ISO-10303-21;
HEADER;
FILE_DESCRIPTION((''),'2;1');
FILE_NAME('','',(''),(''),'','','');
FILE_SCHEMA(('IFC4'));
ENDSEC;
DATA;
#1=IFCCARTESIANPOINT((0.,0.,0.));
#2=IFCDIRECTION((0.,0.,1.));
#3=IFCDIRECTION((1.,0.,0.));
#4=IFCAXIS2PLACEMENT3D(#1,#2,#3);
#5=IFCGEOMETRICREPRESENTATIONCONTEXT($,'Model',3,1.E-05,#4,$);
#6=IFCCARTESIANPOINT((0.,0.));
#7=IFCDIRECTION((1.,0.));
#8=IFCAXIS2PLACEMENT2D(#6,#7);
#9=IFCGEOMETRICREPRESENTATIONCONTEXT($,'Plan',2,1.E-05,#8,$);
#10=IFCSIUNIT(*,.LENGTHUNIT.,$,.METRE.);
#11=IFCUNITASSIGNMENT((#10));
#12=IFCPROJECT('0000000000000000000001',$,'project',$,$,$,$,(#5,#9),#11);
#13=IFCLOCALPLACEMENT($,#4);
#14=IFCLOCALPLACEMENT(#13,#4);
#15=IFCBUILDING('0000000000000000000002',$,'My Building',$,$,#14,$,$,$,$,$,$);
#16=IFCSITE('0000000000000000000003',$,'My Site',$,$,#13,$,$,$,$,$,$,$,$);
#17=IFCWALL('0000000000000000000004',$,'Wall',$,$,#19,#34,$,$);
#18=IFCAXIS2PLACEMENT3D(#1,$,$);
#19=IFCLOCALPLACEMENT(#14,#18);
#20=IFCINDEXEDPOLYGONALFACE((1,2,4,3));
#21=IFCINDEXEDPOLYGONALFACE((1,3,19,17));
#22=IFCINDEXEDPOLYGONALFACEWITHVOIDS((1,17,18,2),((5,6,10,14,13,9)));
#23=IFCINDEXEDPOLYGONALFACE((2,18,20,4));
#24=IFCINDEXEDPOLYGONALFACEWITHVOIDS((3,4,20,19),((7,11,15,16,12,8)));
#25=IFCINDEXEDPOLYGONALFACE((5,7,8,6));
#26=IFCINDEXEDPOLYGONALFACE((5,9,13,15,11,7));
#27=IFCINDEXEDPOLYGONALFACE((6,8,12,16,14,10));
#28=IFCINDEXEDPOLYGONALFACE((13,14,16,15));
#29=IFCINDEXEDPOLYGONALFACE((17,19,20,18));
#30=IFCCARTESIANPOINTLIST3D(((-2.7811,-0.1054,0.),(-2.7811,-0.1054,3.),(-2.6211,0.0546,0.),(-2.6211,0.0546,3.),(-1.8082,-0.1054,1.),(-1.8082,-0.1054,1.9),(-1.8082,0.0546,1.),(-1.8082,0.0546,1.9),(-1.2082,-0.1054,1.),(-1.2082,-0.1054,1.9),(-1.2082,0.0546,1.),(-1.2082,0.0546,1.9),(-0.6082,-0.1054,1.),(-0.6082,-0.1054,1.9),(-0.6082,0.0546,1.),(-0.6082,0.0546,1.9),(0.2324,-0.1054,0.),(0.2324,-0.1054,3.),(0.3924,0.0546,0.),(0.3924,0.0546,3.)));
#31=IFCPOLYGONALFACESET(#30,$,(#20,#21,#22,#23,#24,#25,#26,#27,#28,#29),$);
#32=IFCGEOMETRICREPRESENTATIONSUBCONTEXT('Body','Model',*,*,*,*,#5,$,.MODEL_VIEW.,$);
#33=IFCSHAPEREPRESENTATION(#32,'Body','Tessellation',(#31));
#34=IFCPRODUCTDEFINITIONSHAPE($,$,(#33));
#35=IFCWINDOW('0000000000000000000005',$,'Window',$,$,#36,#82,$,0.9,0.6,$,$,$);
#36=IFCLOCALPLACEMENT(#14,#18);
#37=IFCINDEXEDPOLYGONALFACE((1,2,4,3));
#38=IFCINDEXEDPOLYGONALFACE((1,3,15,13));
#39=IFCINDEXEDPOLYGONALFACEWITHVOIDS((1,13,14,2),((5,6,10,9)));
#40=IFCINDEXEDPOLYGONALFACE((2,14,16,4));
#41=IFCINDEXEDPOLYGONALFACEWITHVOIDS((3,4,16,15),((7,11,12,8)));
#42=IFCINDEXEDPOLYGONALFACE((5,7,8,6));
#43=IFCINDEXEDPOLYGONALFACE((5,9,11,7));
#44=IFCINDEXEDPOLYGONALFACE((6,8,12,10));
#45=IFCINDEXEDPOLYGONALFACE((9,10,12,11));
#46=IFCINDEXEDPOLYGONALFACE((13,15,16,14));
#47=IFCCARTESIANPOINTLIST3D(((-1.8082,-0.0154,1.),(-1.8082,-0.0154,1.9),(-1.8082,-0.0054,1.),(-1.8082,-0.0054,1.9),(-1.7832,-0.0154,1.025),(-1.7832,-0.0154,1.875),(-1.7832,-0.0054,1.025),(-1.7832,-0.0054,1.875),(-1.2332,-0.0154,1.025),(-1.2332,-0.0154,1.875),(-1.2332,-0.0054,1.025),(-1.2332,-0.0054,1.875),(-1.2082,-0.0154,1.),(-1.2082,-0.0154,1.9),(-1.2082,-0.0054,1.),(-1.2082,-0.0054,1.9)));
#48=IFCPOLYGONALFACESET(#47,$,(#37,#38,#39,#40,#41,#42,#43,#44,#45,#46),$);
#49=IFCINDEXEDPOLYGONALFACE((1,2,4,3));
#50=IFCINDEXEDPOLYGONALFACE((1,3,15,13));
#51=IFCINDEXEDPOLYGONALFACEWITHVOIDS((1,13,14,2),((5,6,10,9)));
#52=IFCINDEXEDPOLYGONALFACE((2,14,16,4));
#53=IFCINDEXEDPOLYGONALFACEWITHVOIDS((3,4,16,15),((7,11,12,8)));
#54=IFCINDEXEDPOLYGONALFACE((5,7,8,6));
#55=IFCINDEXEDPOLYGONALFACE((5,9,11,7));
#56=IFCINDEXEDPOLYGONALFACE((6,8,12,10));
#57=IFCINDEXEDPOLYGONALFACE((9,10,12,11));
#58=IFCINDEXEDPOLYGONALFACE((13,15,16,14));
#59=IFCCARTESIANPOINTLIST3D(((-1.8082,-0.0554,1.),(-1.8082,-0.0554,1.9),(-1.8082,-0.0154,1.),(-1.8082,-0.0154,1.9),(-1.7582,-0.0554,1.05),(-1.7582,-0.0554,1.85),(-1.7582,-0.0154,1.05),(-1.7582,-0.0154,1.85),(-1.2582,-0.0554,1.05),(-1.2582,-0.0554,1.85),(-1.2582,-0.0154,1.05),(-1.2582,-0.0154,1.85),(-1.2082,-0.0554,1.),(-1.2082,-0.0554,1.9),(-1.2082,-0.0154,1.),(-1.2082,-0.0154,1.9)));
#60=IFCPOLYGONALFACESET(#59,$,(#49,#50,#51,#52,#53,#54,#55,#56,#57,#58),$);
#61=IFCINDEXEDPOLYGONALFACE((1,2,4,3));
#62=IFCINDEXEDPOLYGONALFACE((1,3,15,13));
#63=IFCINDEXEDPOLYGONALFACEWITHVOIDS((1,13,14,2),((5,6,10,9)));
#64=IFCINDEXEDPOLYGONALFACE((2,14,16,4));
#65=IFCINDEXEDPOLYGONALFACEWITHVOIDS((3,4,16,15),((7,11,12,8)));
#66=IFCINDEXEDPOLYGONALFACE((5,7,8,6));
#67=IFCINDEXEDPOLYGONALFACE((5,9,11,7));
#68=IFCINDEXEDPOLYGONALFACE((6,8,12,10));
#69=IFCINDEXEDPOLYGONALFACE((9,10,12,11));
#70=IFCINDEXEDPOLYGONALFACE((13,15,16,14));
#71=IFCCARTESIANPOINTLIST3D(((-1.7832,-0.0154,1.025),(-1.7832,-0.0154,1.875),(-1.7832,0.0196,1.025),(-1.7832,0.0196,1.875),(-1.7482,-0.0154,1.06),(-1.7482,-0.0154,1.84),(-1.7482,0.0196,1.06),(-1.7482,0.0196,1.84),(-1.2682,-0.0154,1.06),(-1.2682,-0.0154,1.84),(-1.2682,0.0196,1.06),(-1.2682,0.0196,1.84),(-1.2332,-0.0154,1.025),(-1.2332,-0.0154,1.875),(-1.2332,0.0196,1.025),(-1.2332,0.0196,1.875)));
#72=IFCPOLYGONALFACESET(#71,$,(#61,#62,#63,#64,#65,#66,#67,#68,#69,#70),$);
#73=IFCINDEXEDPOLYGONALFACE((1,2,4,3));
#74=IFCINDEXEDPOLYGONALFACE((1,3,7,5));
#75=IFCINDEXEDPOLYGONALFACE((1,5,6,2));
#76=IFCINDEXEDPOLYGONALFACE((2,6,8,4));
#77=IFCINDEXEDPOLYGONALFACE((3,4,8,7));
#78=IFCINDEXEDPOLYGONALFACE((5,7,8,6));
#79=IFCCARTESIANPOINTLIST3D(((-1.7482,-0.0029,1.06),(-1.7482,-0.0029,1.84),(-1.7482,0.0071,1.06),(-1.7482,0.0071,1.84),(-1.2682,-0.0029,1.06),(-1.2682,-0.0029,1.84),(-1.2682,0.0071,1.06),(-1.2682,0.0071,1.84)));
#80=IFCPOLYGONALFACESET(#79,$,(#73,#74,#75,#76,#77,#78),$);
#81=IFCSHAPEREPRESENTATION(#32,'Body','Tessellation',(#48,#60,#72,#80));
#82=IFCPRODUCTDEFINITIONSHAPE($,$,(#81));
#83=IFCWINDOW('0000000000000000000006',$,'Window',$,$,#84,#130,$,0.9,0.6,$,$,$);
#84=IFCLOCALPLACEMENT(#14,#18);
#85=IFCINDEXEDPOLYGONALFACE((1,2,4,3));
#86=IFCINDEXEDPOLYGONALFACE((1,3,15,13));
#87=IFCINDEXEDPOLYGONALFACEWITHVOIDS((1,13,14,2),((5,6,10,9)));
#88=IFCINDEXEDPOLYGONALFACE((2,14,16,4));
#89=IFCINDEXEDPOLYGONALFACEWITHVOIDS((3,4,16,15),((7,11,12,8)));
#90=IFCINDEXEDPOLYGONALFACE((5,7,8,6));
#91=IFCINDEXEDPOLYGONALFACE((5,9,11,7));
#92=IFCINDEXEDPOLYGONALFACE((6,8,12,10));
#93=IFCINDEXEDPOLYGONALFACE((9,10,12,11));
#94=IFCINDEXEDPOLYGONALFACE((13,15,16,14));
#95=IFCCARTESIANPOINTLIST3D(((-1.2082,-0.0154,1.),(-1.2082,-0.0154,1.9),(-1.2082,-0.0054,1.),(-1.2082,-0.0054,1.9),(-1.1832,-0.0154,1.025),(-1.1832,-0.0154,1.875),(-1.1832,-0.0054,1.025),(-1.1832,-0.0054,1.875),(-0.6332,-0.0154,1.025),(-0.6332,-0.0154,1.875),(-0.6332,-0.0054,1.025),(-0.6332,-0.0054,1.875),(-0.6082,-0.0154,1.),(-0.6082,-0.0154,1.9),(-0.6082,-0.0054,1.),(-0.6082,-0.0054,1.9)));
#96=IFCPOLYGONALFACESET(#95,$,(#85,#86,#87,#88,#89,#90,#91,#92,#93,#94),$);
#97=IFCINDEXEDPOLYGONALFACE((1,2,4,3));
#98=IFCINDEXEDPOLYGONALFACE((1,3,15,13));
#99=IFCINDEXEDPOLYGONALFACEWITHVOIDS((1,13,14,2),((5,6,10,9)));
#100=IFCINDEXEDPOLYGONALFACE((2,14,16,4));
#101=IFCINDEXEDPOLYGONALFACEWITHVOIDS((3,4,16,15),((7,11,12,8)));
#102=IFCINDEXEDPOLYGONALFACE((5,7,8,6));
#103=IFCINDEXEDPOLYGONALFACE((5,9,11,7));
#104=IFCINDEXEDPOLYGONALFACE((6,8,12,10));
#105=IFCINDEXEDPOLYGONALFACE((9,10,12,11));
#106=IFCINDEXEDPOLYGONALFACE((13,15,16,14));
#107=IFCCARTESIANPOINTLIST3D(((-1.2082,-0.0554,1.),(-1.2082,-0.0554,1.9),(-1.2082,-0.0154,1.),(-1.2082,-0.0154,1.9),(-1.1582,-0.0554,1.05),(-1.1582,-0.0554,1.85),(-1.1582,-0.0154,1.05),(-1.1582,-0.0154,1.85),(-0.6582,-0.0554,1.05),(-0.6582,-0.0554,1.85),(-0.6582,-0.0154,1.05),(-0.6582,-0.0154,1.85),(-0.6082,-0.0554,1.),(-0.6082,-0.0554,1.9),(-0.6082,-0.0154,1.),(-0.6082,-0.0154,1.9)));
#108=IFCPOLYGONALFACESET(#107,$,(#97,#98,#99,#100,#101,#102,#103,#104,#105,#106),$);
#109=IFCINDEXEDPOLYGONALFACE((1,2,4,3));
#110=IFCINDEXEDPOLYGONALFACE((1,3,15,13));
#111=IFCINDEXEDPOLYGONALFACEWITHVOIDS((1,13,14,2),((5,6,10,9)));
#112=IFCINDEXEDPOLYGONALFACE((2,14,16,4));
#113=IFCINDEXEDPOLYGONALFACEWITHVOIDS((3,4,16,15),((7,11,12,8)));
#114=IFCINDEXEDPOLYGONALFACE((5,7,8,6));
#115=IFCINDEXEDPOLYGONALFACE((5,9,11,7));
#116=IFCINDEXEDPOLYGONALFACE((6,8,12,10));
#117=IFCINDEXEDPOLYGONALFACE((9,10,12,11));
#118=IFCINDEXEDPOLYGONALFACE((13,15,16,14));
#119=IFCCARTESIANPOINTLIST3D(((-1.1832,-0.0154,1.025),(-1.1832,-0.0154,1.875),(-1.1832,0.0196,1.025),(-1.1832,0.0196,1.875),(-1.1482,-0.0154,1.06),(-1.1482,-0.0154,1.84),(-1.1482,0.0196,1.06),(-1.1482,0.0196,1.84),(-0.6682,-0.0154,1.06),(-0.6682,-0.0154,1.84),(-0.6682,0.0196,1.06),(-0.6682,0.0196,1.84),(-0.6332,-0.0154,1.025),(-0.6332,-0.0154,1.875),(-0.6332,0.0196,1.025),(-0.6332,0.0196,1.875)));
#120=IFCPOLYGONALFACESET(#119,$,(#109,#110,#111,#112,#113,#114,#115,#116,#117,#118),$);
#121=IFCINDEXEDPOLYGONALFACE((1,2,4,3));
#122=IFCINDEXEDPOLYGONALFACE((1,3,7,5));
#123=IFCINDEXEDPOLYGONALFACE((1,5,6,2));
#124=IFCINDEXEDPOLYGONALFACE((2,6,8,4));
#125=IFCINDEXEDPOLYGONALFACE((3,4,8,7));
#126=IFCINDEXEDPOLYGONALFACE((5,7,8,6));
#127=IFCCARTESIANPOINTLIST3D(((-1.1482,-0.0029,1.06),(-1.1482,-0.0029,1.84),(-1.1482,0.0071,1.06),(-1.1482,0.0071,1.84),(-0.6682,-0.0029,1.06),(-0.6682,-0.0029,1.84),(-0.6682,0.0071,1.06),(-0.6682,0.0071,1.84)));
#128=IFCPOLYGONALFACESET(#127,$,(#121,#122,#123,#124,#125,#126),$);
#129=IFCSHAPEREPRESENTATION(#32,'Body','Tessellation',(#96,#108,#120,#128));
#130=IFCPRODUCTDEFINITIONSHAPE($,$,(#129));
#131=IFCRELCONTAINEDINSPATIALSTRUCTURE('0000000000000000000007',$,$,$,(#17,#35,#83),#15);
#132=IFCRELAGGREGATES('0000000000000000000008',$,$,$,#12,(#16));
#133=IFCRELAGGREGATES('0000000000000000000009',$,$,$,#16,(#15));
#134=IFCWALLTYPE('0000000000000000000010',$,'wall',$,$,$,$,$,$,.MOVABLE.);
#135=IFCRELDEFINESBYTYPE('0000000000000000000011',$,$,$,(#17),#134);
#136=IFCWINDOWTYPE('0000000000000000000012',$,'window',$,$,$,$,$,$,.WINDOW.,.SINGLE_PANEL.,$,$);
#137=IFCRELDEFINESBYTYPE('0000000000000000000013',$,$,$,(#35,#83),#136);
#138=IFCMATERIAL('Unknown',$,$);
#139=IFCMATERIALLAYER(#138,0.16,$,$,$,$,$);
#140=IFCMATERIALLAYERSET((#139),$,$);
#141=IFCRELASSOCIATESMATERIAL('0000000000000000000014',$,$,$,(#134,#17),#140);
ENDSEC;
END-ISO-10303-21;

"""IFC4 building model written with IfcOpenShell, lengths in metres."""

from ifc_helpers import new_model, entity, si_unit, frame, origin_with_axes, origin_2d_with_axis, place, context, subcontext, project, spatial, line, indexed_curve, outline, extrude, shape, source, transform, mapped, material, layer, layer_set, layer_usage, type_object, type_shapes, element, fill, save


model = new_model("IFC4")

# Units and contexts
model_context = context("Model", 3, precision=1e-05, world=origin_with_axes())
plan_context = context("Plan", 2, precision=1e-05, world=origin_2d_with_axis())
body_context_1 = subcontext(model_context, "Body", "Model", "MODEL_VIEW")
body_context_2 = subcontext(plan_context, "Body", "Plan", "PLAN_VIEW")
ifc_project = project(units=[si_unit("LENGTHUNIT", "METRE")], contexts=[model_context, plan_context])

# Site, building
site_placement = place(None, origin_with_axes())
site = spatial("IfcSite", under=ifc_project, at=site_placement, Name="My Site")
building_placement = place(site_placement, origin_with_axes())
building = spatial("IfcBuilding", under=site, at=building_placement, Name="My Building")

# Shared definitions
ifc_material = material(Name="Unknown")

# Shared definitions
ifc_layer_1 = layer(ifc_material, 0.16)
ifc_layer_set_1 = layer_set([ifc_layer_1])
wall_type_1 = type_object("IfcWallType", Name="wall", PredefinedType="MOVABLE", material=ifc_layer_set_1)
shared_shape_1 = source(origin_with_axes(), body_context_1, "Body", "SweptSolid", [
    extrude(outline(indexed_curve([(0.0, 0.0), (0.6, 0.0), (0.6, 0.9), (0.0, 0.9)], segments=[line(1, 2, 3, 4, 1)])), frame((0.0, -0.6, 0.0), z_axis=(0.0, -1.0, 0.0), x_axis=(1.0, 0.0, 0.0)), (0.0, 0.0, -1.0), 1.2),
])
window_type = type_object("IfcWindowType", Name="window", PartitioningType="SINGLE_PANEL", PredefinedType="WINDOW")
shared_shape_2 = source(origin_with_axes(), body_context_1, "Body", "SweptSolid", [
    extrude(outline(indexed_curve([(0.0, 0.0), (0.6, 0.0), (0.6, 0.9), (0.0, 0.9)], segments=[line(1, 2, 3, 4, 1)]), holes=[indexed_curve([(0.025, 0.025), (0.575, 0.025), (0.575, 0.875), (0.025, 0.875)], segments=[line(1, 2, 3, 4, 1)])]), frame((0.0, 0.09, 0.0), z_axis=(0.0, -1.0, 0.0), x_axis=(1.0, 0.0, 0.0)), (0.0, 0.0, -1.0), 0.01),
    extrude(outline(indexed_curve([(0.0, 0.0), (0.6, 0.0), (0.6, 0.9), (0.0, 0.9)], segments=[line(1, 2, 3, 4, 1)]), holes=[indexed_curve([(0.05, 0.05), (0.55, 0.05), (0.55, 0.85), (0.05, 0.85)], segments=[line(1, 2, 3, 4, 1)])]), frame((0.0, 0.05, 0.0), z_axis=(0.0, -1.0, 0.0), x_axis=(1.0, 0.0, 0.0)), (0.0, 0.0, -1.0), 0.04),
    extrude(outline(indexed_curve([(0.0, 0.0), (0.55, 0.0), (0.55, 0.85), (0.0, 0.85)], segments=[line(1, 2, 3, 4, 1)]), holes=[indexed_curve([(0.035, 0.035), (0.515, 0.035), (0.515, 0.815), (0.035, 0.815)], segments=[line(1, 2, 3, 4, 1)])]), frame((0.025, 0.09, 0.025), z_axis=(0.0, -1.0, 0.0), x_axis=(1.0, 0.0, 0.0)), (0.0, 0.0, -1.0), 0.035),
    extrude(outline(indexed_curve([(0.035, 0.035), (0.515, 0.035), (0.515, 0.815), (0.035, 0.815)], segments=[line(1, 2, 3, 4, 1)])), frame((0.025, 0.1025, 0.025), z_axis=(0.0, -1.0, 0.0), x_axis=(1.0, 0.0, 0.0)), (0.0, 0.0, -1.0), 0.01),
])
shared_shape_3 = source(origin_with_axes(), body_context_2, "Body", "Curve2D", [
    entity("IfcIndexedPolyCurve", entity("IfcCartesianPointList2D", [[0.05, 0.05], [0.55, 0.05]])),
    entity("IfcIndexedPolyCurve", entity("IfcCartesianPointList2D", [[0.0, 0.1], [0.025, 0.1], [0.025, 0.09], [0.05, 0.09], [0.05, 0.05], [0.0, 0.05]]), [entity("IfcLineIndex", [1, 2, 3, 4, 5, 6, 1])]),
    entity("IfcIndexedPolyCurve", entity("IfcCartesianPointList2D", [[0.6, 0.1], [0.575, 0.1], [0.575, 0.09], [0.55, 0.09], [0.55, 0.05], [0.6, 0.05]]), [entity("IfcLineIndex", [1, 2, 3, 4, 5, 6, 1])]),
    entity("IfcIndexedPolyCurve", entity("IfcCartesianPointList2D", [[0.025, 0.09], [0.06, 0.09], [0.06, 0.125], [0.025, 0.125]]), [entity("IfcLineIndex", [1, 2, 3, 4, 1])]),
    entity("IfcIndexedPolyCurve", entity("IfcCartesianPointList2D", [[0.575, 0.09], [0.54, 0.09], [0.54, 0.125], [0.575, 0.125]]), [entity("IfcLineIndex", [1, 2, 3, 4, 1])]),
    entity("IfcIndexedPolyCurve", entity("IfcCartesianPointList2D", [[0.06, 0.09], [0.54, 0.09]])),
    entity("IfcIndexedPolyCurve", entity("IfcCartesianPointList2D", [[0.06, 0.125], [0.54, 0.125]])),
    entity("IfcIndexedPolyCurve", entity("IfcCartesianPointList2D", [[0.06, 0.1075], [0.54, 0.1075]])),
])
type_shapes(window_type, [shared_shape_2, shared_shape_3])

# Wall, openings, windows
ifc_layer_usage_1 = layer_usage(ifc_layer_set_1, "AXIS2", "POSITIVE", 0.0)
wall_1_placement = place(building_placement, frame((0.3924, 0.0546, 0.0), z_axis=(0.0, 0.0, 1.0), x_axis=(-1.0, 0.0, 0.0)))
wall_1 = element("IfcWall", 1, at=wall_1_placement, inside=building, type_object=wall_type_1, material=ifc_layer_usage_1, Name="Wall", context=body_context_1, shape_type="SweptSolid", body=[
    extrude(outline(indexed_curve([(0.0, 0.0), (0.16, 0.16), (3.1735, 0.16), (3.0135, 0.0)], segments=[line(1, 2, 3, 4, 1)])), origin_with_axes(), (0.0, 0.0, 1.0), 3.0),
])
opening_1_placement = place(wall_1_placement, frame((2.2006, 0.16, 1.0), z_axis=(0.0, 0.0, 1.0), x_axis=(-1.0, 0.0, 0.0)))
opening_1 = element("IfcOpeningElement", 2, at=opening_1_placement, cuts=wall_1, PredefinedType="OPENING", context=body_context_1, shape_type="MappedRepresentation", body=[
    mapped(shared_shape_1, transform((0.0, 0.0, 0.0), x_axis=(1.0, 0.0, 0.0), y_axis=(0.0, 1.0, 0.0), z_axis=(0.0, 0.0, 1.0), scale=1.0)),
])
opening_2_placement = place(wall_1_placement, frame((1.6006, 0.16, 1.0), z_axis=(0.0, 0.0, 1.0), x_axis=(-1.0, 0.0, 0.0)))
opening_2 = element("IfcOpeningElement", 3, at=opening_2_placement, cuts=wall_1, PredefinedType="OPENING", context=body_context_1, shape_type="MappedRepresentation", body=[
    mapped(shared_shape_1, transform((0.0, 0.0, 0.0), x_axis=(1.0, 0.0, 0.0), y_axis=(0.0, 1.0, 0.0), z_axis=(0.0, 0.0, 1.0), scale=1.0)),
])
window_1_placement = place(opening_1_placement, frame((0.0, 0.0, 0.0), z_axis=(0.0, 0.0, 1.0), x_axis=(1.0, 0.0, 0.0)))
window_1 = element("IfcWindow", 4, at=window_1_placement, inside=building, type_object=window_type, Name="Window", OverallHeight=0.9, OverallWidth=0.6, shapes=[
    shape(body_context_1, "Body", "MappedRepresentation", [mapped(shared_shape_2, transform((0.0, 0.0, 0.0), x_axis=(1.0, 0.0, 0.0), y_axis=(0.0, 1.0, 0.0), z_axis=(0.0, 0.0, 1.0), scale=1.0))]),
    shape(body_context_2, "Body", "MappedRepresentation", [mapped(shared_shape_3, transform((0.0, 0.0, 0.0), x_axis=(1.0, 0.0, 0.0), y_axis=(0.0, 1.0, 0.0), z_axis=(0.0, 0.0, 1.0), scale=1.0))]),
])
fill(opening_1, window_1)
window_2_placement = place(opening_2_placement, frame((0.0, 0.0, 0.0), z_axis=(0.0, 0.0, 1.0), x_axis=(1.0, 0.0, 0.0)))
window_2 = element("IfcWindow", 5, at=window_2_placement, inside=building, type_object=window_type, Name="Window", OverallHeight=0.9, OverallWidth=0.6, shapes=[
    shape(body_context_1, "Body", "MappedRepresentation", [mapped(shared_shape_2, transform((0.0, 0.0, 0.0), x_axis=(1.0, 0.0, 0.0), y_axis=(0.0, 1.0, 0.0), z_axis=(0.0, 0.0, 1.0), scale=1.0))]),
    shape(body_context_2, "Body", "MappedRepresentation", [mapped(shared_shape_3, transform((0.0, 0.0, 0.0), x_axis=(1.0, 0.0, 0.0), y_axis=(0.0, 1.0, 0.0), z_axis=(0.0, 0.0, 1.0), scale=1.0))]),
])
fill(opening_2, window_2)

save(model, "model.ifc")
